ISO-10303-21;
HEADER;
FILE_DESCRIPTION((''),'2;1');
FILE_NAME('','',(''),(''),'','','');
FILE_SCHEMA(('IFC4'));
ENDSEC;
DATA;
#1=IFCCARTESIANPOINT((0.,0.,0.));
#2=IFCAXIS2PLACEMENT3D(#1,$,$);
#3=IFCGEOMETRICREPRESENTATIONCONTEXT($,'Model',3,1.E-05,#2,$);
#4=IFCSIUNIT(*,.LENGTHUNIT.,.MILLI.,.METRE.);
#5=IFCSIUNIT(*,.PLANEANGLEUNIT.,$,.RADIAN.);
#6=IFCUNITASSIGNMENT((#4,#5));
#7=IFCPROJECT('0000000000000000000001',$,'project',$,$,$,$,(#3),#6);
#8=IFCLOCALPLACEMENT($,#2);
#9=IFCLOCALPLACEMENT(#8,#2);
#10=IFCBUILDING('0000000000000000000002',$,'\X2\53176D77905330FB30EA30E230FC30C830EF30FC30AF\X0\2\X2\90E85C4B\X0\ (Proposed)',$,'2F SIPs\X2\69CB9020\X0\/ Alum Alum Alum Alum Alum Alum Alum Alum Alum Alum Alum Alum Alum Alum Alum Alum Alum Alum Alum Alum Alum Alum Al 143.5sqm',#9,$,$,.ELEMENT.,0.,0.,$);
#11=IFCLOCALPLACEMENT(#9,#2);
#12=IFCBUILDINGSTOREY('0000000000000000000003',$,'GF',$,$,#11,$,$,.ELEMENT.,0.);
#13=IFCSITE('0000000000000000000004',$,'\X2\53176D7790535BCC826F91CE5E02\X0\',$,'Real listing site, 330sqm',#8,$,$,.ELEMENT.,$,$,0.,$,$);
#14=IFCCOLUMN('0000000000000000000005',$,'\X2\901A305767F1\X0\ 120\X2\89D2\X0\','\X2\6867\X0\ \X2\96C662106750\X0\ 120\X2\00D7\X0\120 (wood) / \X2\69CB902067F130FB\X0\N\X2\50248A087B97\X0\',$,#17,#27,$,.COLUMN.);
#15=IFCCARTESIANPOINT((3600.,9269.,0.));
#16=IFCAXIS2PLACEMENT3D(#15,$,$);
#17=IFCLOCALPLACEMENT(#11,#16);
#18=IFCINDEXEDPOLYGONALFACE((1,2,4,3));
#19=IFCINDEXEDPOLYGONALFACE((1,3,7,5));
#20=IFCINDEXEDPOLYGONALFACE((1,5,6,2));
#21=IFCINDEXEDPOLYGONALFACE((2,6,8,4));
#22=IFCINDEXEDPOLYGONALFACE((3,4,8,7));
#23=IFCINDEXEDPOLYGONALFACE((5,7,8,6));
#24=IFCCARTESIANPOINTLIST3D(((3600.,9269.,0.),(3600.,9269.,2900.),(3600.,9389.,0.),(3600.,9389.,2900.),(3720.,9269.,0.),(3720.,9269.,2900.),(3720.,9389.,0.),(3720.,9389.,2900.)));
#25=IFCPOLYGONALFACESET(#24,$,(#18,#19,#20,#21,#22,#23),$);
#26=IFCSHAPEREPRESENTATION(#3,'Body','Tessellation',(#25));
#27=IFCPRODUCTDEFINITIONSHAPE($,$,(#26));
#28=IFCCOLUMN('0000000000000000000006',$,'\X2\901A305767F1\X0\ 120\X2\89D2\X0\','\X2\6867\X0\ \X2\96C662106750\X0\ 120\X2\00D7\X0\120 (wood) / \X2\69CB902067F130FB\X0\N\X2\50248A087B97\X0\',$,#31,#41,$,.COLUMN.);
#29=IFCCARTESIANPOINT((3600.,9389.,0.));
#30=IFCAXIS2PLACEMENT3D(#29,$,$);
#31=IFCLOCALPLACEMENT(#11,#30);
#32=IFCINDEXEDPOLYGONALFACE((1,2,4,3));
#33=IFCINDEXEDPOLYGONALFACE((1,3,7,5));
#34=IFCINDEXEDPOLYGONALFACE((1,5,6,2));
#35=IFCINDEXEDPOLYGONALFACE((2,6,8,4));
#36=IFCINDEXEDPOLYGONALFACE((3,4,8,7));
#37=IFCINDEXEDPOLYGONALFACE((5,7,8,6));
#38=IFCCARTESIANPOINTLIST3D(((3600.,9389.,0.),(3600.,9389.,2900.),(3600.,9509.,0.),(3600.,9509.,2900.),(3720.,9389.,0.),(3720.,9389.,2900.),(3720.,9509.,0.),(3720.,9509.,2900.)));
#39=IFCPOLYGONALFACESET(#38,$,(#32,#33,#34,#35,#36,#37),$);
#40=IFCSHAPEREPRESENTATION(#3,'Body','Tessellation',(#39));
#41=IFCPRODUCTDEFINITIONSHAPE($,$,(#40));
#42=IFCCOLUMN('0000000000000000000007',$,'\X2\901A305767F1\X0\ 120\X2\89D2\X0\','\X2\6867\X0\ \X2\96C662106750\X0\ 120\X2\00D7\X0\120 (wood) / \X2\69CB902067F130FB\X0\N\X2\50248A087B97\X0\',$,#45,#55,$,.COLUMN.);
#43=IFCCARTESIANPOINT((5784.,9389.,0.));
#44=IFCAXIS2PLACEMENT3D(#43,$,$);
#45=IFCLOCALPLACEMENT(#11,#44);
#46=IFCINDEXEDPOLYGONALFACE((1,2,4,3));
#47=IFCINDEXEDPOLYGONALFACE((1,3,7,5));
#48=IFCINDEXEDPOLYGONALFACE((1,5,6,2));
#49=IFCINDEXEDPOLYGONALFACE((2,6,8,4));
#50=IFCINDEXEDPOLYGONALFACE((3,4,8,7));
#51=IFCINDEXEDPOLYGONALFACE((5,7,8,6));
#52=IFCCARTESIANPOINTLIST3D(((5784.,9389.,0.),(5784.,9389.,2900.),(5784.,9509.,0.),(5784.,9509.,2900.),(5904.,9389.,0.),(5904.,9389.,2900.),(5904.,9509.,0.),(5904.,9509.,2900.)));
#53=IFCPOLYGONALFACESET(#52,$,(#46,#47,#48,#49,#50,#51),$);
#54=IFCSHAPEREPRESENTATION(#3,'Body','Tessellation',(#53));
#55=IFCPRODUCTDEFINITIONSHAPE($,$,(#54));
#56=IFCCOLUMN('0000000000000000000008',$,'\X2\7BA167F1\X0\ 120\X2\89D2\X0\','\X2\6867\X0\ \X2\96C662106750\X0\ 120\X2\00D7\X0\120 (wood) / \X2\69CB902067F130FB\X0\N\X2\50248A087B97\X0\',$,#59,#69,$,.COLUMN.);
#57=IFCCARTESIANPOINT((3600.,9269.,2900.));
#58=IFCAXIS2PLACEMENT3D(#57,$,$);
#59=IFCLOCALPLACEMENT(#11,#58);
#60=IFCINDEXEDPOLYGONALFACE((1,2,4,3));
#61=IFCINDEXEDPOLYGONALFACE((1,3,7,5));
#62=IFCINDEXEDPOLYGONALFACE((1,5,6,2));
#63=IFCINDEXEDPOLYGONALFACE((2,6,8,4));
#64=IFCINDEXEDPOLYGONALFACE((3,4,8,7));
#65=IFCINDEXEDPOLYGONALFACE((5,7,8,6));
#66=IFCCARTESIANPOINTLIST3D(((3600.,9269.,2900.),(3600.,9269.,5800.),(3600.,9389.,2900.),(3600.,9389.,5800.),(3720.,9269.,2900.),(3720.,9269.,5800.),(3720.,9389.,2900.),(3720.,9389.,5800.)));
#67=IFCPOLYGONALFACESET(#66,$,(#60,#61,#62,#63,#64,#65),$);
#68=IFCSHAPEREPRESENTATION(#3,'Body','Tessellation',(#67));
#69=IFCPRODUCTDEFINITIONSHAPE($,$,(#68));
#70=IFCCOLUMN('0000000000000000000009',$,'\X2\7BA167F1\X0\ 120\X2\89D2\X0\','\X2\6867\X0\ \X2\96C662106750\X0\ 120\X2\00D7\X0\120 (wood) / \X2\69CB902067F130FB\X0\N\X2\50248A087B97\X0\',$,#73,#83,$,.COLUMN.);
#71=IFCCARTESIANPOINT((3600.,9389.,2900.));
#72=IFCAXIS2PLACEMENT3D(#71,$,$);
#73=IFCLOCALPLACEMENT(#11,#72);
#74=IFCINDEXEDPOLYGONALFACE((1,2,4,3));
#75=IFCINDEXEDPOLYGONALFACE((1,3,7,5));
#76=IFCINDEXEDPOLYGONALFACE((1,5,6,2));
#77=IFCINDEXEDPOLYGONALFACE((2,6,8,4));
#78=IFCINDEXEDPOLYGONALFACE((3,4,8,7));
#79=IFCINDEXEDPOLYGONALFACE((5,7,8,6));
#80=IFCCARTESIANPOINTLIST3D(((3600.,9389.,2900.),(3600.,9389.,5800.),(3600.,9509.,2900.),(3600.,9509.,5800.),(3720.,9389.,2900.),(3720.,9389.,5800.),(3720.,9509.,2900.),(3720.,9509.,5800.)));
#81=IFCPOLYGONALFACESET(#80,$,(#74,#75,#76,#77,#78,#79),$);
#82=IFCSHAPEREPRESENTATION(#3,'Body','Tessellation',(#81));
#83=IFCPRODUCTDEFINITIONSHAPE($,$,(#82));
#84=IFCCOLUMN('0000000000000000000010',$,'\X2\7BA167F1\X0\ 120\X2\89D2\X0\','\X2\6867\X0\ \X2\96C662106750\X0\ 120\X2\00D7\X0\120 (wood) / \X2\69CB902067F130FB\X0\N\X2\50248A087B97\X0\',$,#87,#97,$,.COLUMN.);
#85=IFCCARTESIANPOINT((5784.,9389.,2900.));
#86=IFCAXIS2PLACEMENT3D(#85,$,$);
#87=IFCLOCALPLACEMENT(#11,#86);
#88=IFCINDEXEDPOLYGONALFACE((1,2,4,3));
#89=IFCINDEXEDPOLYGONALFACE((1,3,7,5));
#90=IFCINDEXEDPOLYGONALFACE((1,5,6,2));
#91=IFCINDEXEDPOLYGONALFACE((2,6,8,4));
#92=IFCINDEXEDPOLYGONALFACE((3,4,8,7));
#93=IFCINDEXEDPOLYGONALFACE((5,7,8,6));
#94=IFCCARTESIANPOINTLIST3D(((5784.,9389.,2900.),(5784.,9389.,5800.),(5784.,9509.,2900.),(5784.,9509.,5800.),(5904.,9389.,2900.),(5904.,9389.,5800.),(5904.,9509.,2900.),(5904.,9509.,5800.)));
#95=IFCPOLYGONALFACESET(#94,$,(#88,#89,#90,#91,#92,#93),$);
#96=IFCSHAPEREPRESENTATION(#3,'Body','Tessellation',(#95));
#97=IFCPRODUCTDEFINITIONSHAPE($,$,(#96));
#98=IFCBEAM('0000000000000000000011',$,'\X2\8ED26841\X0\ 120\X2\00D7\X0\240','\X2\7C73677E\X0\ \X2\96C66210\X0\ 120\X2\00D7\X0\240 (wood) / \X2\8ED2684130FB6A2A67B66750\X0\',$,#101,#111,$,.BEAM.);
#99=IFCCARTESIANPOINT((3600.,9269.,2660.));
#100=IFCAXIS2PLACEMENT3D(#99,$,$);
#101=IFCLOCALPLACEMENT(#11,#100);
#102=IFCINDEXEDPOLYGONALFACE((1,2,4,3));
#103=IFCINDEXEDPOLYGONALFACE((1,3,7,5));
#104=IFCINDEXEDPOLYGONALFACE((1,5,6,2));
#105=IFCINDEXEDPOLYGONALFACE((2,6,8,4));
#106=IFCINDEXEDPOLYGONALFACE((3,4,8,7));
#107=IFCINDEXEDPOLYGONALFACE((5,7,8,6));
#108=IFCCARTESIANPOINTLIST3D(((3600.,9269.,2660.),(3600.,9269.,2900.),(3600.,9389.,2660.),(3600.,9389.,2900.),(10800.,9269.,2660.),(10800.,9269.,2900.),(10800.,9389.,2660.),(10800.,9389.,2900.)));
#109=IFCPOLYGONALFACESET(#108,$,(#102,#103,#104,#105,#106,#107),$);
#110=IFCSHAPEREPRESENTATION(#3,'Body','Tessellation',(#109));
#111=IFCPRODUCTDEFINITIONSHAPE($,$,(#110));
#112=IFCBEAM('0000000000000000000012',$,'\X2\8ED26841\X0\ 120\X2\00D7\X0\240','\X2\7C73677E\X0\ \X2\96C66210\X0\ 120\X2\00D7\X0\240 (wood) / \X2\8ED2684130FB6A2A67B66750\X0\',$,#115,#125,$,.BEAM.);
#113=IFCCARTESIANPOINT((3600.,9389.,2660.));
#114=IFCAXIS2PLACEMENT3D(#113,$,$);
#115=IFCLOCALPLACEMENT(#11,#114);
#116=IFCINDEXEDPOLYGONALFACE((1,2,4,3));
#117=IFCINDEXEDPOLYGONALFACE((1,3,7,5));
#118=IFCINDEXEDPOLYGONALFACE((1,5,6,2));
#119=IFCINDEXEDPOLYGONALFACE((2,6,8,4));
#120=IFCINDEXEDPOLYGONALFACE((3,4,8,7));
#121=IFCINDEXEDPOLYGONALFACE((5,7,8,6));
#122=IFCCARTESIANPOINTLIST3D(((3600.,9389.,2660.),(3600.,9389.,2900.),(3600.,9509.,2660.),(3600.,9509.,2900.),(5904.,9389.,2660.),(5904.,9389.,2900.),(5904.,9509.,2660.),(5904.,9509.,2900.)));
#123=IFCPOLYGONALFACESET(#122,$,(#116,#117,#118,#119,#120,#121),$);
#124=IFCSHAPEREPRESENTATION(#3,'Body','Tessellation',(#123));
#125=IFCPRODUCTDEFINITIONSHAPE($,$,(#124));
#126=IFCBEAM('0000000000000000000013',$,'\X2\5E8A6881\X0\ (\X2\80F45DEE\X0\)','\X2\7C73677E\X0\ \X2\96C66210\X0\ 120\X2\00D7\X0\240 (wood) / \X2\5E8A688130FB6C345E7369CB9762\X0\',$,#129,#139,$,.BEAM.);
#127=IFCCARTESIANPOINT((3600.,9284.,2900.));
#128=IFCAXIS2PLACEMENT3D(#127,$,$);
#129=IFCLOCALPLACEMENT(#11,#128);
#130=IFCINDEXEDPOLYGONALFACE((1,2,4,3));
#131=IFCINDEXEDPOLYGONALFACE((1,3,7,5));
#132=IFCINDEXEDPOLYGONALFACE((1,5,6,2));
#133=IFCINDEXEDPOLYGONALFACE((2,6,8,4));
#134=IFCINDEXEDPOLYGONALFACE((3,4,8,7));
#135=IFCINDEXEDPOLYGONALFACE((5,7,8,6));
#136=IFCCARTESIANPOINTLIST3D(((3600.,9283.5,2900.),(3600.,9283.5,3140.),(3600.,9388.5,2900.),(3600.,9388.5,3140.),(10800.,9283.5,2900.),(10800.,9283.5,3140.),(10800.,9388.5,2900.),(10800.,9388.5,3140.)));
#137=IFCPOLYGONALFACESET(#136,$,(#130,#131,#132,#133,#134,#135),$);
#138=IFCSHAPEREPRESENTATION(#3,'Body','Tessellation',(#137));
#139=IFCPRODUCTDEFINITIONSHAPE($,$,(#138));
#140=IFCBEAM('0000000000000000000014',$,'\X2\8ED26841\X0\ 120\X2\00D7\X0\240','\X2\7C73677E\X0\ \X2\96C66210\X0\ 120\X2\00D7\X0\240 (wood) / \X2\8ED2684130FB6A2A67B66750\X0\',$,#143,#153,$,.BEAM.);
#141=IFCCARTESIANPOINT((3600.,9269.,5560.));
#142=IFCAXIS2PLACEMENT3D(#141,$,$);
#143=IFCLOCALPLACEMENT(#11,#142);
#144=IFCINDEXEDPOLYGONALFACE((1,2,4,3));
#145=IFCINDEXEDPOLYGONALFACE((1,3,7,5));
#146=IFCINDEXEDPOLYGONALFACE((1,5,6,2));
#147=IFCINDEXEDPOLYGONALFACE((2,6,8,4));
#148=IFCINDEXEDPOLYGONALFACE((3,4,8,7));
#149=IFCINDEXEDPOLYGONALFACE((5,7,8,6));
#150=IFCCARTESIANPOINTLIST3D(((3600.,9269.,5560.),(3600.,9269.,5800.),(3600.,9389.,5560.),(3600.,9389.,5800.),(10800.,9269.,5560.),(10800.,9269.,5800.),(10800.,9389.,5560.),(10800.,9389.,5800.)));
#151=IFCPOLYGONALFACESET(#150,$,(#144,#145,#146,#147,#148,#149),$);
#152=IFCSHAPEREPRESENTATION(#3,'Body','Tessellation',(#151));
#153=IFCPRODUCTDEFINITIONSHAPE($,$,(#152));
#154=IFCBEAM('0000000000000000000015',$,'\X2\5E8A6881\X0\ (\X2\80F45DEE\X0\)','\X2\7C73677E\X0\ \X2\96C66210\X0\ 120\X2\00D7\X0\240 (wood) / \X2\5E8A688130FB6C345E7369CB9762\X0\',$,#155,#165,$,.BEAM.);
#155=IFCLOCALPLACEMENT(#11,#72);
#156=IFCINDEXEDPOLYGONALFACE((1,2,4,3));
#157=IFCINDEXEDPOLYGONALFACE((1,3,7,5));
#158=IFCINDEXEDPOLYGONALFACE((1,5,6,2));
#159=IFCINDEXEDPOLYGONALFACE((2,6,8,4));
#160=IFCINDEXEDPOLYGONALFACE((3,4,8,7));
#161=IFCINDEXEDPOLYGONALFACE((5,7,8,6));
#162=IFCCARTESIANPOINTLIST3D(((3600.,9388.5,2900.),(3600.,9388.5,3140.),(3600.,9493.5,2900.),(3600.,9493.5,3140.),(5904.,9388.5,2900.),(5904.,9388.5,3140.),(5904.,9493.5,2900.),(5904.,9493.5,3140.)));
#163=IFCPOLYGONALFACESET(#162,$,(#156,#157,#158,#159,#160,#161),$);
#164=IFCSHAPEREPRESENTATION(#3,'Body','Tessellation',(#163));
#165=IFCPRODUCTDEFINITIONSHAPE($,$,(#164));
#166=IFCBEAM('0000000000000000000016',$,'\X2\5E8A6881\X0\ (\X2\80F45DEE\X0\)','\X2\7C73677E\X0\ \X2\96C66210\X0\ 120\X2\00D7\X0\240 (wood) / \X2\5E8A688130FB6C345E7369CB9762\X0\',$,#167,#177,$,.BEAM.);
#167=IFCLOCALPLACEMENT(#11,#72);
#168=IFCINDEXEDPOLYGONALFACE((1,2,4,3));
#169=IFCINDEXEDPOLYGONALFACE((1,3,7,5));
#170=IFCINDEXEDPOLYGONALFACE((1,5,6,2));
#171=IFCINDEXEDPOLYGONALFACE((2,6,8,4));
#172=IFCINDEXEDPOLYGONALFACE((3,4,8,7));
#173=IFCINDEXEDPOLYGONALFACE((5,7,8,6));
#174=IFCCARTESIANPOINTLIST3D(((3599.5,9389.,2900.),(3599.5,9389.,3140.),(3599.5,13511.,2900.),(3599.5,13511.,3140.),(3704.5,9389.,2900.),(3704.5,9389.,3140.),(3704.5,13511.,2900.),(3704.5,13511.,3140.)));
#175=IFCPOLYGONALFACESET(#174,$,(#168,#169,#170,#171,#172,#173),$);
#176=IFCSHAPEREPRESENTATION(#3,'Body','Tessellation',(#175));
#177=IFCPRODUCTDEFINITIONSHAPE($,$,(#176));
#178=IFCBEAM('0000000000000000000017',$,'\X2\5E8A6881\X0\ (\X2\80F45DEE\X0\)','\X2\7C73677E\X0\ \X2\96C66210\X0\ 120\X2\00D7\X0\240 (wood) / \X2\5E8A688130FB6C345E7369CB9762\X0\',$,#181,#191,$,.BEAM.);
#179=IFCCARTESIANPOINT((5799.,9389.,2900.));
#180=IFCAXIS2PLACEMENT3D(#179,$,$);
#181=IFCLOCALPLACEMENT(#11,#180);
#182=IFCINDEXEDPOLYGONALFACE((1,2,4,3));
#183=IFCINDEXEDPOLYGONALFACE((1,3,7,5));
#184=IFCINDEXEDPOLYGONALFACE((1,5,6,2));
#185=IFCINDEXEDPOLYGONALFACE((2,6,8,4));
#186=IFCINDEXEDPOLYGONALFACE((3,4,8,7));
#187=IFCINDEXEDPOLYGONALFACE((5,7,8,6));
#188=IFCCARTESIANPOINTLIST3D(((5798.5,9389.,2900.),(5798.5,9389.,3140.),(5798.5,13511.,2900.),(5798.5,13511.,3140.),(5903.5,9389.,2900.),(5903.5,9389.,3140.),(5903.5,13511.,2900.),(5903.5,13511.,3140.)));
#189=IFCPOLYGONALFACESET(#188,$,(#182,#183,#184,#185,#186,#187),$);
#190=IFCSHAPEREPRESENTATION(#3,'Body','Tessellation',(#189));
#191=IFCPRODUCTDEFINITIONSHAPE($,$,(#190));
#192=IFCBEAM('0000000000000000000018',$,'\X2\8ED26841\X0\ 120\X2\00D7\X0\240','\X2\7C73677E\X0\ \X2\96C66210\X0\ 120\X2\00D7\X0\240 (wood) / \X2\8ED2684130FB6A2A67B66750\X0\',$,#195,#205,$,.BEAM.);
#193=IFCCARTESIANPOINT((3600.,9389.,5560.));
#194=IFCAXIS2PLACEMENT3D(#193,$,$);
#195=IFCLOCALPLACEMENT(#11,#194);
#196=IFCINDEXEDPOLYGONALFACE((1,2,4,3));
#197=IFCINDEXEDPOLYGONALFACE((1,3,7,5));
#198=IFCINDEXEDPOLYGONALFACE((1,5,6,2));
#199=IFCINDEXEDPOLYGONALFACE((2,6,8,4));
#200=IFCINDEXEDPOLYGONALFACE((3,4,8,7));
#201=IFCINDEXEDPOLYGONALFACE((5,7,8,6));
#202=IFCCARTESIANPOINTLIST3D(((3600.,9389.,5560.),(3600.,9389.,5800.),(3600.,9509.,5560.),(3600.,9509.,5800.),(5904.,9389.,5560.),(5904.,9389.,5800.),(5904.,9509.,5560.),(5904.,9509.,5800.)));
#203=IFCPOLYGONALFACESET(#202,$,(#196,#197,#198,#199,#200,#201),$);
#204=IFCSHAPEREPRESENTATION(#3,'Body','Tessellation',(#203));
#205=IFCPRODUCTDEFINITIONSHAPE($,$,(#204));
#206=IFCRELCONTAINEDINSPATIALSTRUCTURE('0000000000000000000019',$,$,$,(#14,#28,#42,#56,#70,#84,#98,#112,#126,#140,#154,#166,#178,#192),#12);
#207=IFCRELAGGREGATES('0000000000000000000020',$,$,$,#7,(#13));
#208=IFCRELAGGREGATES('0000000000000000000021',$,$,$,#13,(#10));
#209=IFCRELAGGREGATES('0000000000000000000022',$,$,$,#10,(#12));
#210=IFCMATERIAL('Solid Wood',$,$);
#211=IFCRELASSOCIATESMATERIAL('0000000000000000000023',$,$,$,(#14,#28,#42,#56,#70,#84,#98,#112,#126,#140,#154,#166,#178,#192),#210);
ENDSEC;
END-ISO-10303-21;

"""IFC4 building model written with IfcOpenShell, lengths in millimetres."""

from ifc_helpers import new_model, si_unit, frame, frame_2d, origin, place, context, project, spatial, rectangle, extrude, material, element, save


model = new_model("IFC4")

# Units and contexts
model_context = context("Model", 3, precision=1e-05, world=origin())
ifc_project = project(units=[si_unit("LENGTHUNIT", "METRE", prefix="MILLI"), si_unit("PLANEANGLEUNIT", "RADIAN")], contexts=[model_context])

# Site, building, storey
site_placement = place(None, origin())
site = spatial("IfcSite", under=ifc_project, at=site_placement, Name="北海道富良野市", ObjectType="Real listing site, 330sqm", CompositionType="ELEMENT", RefElevation=0.0)
building_placement = place(site_placement, origin())
building = spatial("IfcBuilding", under=site, at=building_placement, Name="北海道・リモートワーク2部屋 (Proposed)", ObjectType="2F SIPs構造/ Alum Alum Alum Alum Alum Alum Alum Alum Alum Alum Alum Alum Alum Alum Alum Alum Alum Alum Alum Alum Alum Alum Al 143.5sqm", CompositionType="ELEMENT", ElevationOfRefHeight=0.0, ElevationOfTerrain=0.0)
storey_placement = place(building_placement, origin())
storey = spatial("IfcBuildingStorey", under=building, at=storey_placement, Name="GF", CompositionType="ELEMENT", Elevation=0.0)

# Columns
ifc_material_1 = material(Name="Solid Wood")
column_1_placement = place(storey_placement, frame((3600.0, 9269.0, 0.0)))
element("IfcColumn", 1, at=column_1_placement, inside=storey, material=ifc_material_1, Name="通し柱 120角", Description="桧 集成材 120×120 (wood) / 構造柱・N値計算", PredefinedType="COLUMN", context=model_context, shape_type="SweptSolid", body=[
    extrude(rectangle(XDim=120.0, YDim=120.0, at=frame_2d((60.0, 60.0))), frame((3600.0, 9269.0, 0.0)), (0.0, 0.0, 1.0), 2900.0),
])
column_2_placement = place(storey_placement, frame((3600.0, 9389.0, 0.0)))
element("IfcColumn", 2, at=column_2_placement, inside=storey, material=ifc_material_1, Name="通し柱 120角", Description="桧 集成材 120×120 (wood) / 構造柱・N値計算", PredefinedType="COLUMN", context=model_context, shape_type="SweptSolid", body=[
    extrude(rectangle(XDim=120.0, YDim=120.0, at=frame_2d((60.0, 60.0))), frame((3600.0, 9389.0, 0.0)), (0.0, 0.0, 1.0), 2900.0),
])
column_3_placement = place(storey_placement, frame((5784.0, 9389.0, 0.0)))
element("IfcColumn", 3, at=column_3_placement, inside=storey, material=ifc_material_1, Name="通し柱 120角", Description="桧 集成材 120×120 (wood) / 構造柱・N値計算", PredefinedType="COLUMN", context=model_context, shape_type="SweptSolid", body=[
    extrude(rectangle(XDim=120.0, YDim=120.0, at=frame_2d((60.0, 60.0))), frame((5784.0, 9389.0, 0.0)), (0.0, 0.0, 1.0), 2900.0),
])
column_4_placement = place(storey_placement, frame((3600.0, 9269.0, 2900.0)))
element("IfcColumn", 4, at=column_4_placement, inside=storey, material=ifc_material_1, Name="管柱 120角", Description="桧 集成材 120×120 (wood) / 構造柱・N値計算", PredefinedType="COLUMN", context=model_context, shape_type="SweptSolid", body=[
    extrude(rectangle(XDim=120.0, YDim=120.0, at=frame_2d((60.0, 60.0))), frame((3600.0, 9269.0, 2900.0)), (0.0, 0.0, 1.0), 2900.0),
])
column_5_placement = place(storey_placement, frame((3600.0, 9389.0, 2900.0)))
element("IfcColumn", 5, at=column_5_placement, inside=storey, material=ifc_material_1, Name="管柱 120角", Description="桧 集成材 120×120 (wood) / 構造柱・N値計算", PredefinedType="COLUMN", context=model_context, shape_type="SweptSolid", body=[
    extrude(rectangle(XDim=120.0, YDim=120.0, at=frame_2d((60.0, 60.0))), frame((3600.0, 9389.0, 2900.0)), (0.0, 0.0, 1.0), 2900.0),
])
column_6_placement = place(storey_placement, frame((5784.0, 9389.0, 2900.0)))
element("IfcColumn", 6, at=column_6_placement, inside=storey, material=ifc_material_1, Name="管柱 120角", Description="桧 集成材 120×120 (wood) / 構造柱・N値計算", PredefinedType="COLUMN", context=model_context, shape_type="SweptSolid", body=[
    extrude(rectangle(XDim=120.0, YDim=120.0, at=frame_2d((60.0, 60.0))), frame((5784.0, 9389.0, 2900.0)), (0.0, 0.0, 1.0), 2900.0),
])

# Beams
beam_1_placement = place(storey_placement, frame((3600.0, 9269.0, 2660.0)))
element("IfcBeam", 7, at=beam_1_placement, inside=storey, material=ifc_material_1, Name="軒桁 120×240", Description="米松 集成 120×240 (wood) / 軒桁・横架材", PredefinedType="BEAM", context=model_context, shape_type="SweptSolid", body=[
    extrude(rectangle(XDim=7200.0, YDim=120.0, at=frame_2d((3600.0, 60.0))), frame((3600.0, 9269.0, 2660.0)), (0.0, 0.0, 1.0), 240.0),
])
beam_2_placement = place(storey_placement, frame((3600.0, 9389.0, 2660.0)))
element("IfcBeam", 8, at=beam_2_placement, inside=storey, material=ifc_material_1, Name="軒桁 120×240", Description="米松 集成 120×240 (wood) / 軒桁・横架材", PredefinedType="BEAM", context=model_context, shape_type="SweptSolid", body=[
    extrude(rectangle(XDim=2304.0, YDim=120.0, at=frame_2d((1152.0, 60.0))), frame((3600.0, 9389.0, 2660.0)), (0.0, 0.0, 1.0), 240.0),
])
beam_3_placement = place(storey_placement, frame((3600.0, 9284.0, 2900.0)))
element("IfcBeam", 9, at=beam_3_placement, inside=storey, material=ifc_material_1, Name="床梁 (胴差)", Description="米松 集成 120×240 (wood) / 床梁・水平構面", PredefinedType="BEAM", context=model_context, shape_type="SweptSolid", body=[
    extrude(rectangle(XDim=7200.0, YDim=105.0, at=frame_2d((3600.0, 52.0))), frame((3600.0, 9284.0, 2900.0)), (0.0, 0.0, 1.0), 240.0),
])
beam_4_placement = place(storey_placement, frame((3600.0, 9269.0, 5560.0)))
element("IfcBeam", 10, at=beam_4_placement, inside=storey, material=ifc_material_1, Name="軒桁 120×240", Description="米松 集成 120×240 (wood) / 軒桁・横架材", PredefinedType="BEAM", context=model_context, shape_type="SweptSolid", body=[
    extrude(rectangle(XDim=7200.0, YDim=120.0, at=frame_2d((3600.0, 60.0))), frame((3600.0, 9269.0, 5560.0)), (0.0, 0.0, 1.0), 240.0),
])
beam_5_placement = place(storey_placement, frame((3600.0, 9389.0, 2900.0)))
element("IfcBeam", 11, at=beam_5_placement, inside=storey, material=ifc_material_1, Name="床梁 (胴差)", Description="米松 集成 120×240 (wood) / 床梁・水平構面", PredefinedType="BEAM", context=model_context, shape_type="SweptSolid", body=[
    extrude(rectangle(XDim=2304.0, YDim=105.0, at=frame_2d((1152.0, 52.0))), frame((3600.0, 9389.0, 2900.0)), (0.0, 0.0, 1.0), 240.0),
])
beam_6_placement = place(storey_placement, frame((3600.0, 9389.0, 2900.0)))
element("IfcBeam", 12, at=beam_6_placement, inside=storey, material=ifc_material_1, Name="床梁 (胴差)", Description="米松 集成 120×240 (wood) / 床梁・水平構面", PredefinedType="BEAM", context=model_context, shape_type="SweptSolid", body=[
    extrude(rectangle(XDim=105.0, YDim=4122.0, at=frame_2d((52.0, 2061.0))), frame((3600.0, 9389.0, 2900.0)), (0.0, 0.0, 1.0), 240.0),
])
beam_7_placement = place(storey_placement, frame((5799.0, 9389.0, 2900.0)))
element("IfcBeam", 13, at=beam_7_placement, inside=storey, material=ifc_material_1, Name="床梁 (胴差)", Description="米松 集成 120×240 (wood) / 床梁・水平構面", PredefinedType="BEAM", context=model_context, shape_type="SweptSolid", body=[
    extrude(rectangle(XDim=105.0, YDim=4122.0, at=frame_2d((52.0, 2061.0))), frame((5799.0, 9389.0, 2900.0)), (0.0, 0.0, 1.0), 240.0),
])
beam_8_placement = place(storey_placement, frame((3600.0, 9389.0, 5560.0)))
element("IfcBeam", 14, at=beam_8_placement, inside=storey, material=ifc_material_1, Name="軒桁 120×240", Description="米松 集成 120×240 (wood) / 軒桁・横架材", PredefinedType="BEAM", context=model_context, shape_type="SweptSolid", body=[
    extrude(rectangle(XDim=2304.0, YDim=120.0, at=frame_2d((1152.0, 60.0))), frame((3600.0, 9389.0, 5560.0)), (0.0, 0.0, 1.0), 240.0),
])

save(model, "model.ifc")
